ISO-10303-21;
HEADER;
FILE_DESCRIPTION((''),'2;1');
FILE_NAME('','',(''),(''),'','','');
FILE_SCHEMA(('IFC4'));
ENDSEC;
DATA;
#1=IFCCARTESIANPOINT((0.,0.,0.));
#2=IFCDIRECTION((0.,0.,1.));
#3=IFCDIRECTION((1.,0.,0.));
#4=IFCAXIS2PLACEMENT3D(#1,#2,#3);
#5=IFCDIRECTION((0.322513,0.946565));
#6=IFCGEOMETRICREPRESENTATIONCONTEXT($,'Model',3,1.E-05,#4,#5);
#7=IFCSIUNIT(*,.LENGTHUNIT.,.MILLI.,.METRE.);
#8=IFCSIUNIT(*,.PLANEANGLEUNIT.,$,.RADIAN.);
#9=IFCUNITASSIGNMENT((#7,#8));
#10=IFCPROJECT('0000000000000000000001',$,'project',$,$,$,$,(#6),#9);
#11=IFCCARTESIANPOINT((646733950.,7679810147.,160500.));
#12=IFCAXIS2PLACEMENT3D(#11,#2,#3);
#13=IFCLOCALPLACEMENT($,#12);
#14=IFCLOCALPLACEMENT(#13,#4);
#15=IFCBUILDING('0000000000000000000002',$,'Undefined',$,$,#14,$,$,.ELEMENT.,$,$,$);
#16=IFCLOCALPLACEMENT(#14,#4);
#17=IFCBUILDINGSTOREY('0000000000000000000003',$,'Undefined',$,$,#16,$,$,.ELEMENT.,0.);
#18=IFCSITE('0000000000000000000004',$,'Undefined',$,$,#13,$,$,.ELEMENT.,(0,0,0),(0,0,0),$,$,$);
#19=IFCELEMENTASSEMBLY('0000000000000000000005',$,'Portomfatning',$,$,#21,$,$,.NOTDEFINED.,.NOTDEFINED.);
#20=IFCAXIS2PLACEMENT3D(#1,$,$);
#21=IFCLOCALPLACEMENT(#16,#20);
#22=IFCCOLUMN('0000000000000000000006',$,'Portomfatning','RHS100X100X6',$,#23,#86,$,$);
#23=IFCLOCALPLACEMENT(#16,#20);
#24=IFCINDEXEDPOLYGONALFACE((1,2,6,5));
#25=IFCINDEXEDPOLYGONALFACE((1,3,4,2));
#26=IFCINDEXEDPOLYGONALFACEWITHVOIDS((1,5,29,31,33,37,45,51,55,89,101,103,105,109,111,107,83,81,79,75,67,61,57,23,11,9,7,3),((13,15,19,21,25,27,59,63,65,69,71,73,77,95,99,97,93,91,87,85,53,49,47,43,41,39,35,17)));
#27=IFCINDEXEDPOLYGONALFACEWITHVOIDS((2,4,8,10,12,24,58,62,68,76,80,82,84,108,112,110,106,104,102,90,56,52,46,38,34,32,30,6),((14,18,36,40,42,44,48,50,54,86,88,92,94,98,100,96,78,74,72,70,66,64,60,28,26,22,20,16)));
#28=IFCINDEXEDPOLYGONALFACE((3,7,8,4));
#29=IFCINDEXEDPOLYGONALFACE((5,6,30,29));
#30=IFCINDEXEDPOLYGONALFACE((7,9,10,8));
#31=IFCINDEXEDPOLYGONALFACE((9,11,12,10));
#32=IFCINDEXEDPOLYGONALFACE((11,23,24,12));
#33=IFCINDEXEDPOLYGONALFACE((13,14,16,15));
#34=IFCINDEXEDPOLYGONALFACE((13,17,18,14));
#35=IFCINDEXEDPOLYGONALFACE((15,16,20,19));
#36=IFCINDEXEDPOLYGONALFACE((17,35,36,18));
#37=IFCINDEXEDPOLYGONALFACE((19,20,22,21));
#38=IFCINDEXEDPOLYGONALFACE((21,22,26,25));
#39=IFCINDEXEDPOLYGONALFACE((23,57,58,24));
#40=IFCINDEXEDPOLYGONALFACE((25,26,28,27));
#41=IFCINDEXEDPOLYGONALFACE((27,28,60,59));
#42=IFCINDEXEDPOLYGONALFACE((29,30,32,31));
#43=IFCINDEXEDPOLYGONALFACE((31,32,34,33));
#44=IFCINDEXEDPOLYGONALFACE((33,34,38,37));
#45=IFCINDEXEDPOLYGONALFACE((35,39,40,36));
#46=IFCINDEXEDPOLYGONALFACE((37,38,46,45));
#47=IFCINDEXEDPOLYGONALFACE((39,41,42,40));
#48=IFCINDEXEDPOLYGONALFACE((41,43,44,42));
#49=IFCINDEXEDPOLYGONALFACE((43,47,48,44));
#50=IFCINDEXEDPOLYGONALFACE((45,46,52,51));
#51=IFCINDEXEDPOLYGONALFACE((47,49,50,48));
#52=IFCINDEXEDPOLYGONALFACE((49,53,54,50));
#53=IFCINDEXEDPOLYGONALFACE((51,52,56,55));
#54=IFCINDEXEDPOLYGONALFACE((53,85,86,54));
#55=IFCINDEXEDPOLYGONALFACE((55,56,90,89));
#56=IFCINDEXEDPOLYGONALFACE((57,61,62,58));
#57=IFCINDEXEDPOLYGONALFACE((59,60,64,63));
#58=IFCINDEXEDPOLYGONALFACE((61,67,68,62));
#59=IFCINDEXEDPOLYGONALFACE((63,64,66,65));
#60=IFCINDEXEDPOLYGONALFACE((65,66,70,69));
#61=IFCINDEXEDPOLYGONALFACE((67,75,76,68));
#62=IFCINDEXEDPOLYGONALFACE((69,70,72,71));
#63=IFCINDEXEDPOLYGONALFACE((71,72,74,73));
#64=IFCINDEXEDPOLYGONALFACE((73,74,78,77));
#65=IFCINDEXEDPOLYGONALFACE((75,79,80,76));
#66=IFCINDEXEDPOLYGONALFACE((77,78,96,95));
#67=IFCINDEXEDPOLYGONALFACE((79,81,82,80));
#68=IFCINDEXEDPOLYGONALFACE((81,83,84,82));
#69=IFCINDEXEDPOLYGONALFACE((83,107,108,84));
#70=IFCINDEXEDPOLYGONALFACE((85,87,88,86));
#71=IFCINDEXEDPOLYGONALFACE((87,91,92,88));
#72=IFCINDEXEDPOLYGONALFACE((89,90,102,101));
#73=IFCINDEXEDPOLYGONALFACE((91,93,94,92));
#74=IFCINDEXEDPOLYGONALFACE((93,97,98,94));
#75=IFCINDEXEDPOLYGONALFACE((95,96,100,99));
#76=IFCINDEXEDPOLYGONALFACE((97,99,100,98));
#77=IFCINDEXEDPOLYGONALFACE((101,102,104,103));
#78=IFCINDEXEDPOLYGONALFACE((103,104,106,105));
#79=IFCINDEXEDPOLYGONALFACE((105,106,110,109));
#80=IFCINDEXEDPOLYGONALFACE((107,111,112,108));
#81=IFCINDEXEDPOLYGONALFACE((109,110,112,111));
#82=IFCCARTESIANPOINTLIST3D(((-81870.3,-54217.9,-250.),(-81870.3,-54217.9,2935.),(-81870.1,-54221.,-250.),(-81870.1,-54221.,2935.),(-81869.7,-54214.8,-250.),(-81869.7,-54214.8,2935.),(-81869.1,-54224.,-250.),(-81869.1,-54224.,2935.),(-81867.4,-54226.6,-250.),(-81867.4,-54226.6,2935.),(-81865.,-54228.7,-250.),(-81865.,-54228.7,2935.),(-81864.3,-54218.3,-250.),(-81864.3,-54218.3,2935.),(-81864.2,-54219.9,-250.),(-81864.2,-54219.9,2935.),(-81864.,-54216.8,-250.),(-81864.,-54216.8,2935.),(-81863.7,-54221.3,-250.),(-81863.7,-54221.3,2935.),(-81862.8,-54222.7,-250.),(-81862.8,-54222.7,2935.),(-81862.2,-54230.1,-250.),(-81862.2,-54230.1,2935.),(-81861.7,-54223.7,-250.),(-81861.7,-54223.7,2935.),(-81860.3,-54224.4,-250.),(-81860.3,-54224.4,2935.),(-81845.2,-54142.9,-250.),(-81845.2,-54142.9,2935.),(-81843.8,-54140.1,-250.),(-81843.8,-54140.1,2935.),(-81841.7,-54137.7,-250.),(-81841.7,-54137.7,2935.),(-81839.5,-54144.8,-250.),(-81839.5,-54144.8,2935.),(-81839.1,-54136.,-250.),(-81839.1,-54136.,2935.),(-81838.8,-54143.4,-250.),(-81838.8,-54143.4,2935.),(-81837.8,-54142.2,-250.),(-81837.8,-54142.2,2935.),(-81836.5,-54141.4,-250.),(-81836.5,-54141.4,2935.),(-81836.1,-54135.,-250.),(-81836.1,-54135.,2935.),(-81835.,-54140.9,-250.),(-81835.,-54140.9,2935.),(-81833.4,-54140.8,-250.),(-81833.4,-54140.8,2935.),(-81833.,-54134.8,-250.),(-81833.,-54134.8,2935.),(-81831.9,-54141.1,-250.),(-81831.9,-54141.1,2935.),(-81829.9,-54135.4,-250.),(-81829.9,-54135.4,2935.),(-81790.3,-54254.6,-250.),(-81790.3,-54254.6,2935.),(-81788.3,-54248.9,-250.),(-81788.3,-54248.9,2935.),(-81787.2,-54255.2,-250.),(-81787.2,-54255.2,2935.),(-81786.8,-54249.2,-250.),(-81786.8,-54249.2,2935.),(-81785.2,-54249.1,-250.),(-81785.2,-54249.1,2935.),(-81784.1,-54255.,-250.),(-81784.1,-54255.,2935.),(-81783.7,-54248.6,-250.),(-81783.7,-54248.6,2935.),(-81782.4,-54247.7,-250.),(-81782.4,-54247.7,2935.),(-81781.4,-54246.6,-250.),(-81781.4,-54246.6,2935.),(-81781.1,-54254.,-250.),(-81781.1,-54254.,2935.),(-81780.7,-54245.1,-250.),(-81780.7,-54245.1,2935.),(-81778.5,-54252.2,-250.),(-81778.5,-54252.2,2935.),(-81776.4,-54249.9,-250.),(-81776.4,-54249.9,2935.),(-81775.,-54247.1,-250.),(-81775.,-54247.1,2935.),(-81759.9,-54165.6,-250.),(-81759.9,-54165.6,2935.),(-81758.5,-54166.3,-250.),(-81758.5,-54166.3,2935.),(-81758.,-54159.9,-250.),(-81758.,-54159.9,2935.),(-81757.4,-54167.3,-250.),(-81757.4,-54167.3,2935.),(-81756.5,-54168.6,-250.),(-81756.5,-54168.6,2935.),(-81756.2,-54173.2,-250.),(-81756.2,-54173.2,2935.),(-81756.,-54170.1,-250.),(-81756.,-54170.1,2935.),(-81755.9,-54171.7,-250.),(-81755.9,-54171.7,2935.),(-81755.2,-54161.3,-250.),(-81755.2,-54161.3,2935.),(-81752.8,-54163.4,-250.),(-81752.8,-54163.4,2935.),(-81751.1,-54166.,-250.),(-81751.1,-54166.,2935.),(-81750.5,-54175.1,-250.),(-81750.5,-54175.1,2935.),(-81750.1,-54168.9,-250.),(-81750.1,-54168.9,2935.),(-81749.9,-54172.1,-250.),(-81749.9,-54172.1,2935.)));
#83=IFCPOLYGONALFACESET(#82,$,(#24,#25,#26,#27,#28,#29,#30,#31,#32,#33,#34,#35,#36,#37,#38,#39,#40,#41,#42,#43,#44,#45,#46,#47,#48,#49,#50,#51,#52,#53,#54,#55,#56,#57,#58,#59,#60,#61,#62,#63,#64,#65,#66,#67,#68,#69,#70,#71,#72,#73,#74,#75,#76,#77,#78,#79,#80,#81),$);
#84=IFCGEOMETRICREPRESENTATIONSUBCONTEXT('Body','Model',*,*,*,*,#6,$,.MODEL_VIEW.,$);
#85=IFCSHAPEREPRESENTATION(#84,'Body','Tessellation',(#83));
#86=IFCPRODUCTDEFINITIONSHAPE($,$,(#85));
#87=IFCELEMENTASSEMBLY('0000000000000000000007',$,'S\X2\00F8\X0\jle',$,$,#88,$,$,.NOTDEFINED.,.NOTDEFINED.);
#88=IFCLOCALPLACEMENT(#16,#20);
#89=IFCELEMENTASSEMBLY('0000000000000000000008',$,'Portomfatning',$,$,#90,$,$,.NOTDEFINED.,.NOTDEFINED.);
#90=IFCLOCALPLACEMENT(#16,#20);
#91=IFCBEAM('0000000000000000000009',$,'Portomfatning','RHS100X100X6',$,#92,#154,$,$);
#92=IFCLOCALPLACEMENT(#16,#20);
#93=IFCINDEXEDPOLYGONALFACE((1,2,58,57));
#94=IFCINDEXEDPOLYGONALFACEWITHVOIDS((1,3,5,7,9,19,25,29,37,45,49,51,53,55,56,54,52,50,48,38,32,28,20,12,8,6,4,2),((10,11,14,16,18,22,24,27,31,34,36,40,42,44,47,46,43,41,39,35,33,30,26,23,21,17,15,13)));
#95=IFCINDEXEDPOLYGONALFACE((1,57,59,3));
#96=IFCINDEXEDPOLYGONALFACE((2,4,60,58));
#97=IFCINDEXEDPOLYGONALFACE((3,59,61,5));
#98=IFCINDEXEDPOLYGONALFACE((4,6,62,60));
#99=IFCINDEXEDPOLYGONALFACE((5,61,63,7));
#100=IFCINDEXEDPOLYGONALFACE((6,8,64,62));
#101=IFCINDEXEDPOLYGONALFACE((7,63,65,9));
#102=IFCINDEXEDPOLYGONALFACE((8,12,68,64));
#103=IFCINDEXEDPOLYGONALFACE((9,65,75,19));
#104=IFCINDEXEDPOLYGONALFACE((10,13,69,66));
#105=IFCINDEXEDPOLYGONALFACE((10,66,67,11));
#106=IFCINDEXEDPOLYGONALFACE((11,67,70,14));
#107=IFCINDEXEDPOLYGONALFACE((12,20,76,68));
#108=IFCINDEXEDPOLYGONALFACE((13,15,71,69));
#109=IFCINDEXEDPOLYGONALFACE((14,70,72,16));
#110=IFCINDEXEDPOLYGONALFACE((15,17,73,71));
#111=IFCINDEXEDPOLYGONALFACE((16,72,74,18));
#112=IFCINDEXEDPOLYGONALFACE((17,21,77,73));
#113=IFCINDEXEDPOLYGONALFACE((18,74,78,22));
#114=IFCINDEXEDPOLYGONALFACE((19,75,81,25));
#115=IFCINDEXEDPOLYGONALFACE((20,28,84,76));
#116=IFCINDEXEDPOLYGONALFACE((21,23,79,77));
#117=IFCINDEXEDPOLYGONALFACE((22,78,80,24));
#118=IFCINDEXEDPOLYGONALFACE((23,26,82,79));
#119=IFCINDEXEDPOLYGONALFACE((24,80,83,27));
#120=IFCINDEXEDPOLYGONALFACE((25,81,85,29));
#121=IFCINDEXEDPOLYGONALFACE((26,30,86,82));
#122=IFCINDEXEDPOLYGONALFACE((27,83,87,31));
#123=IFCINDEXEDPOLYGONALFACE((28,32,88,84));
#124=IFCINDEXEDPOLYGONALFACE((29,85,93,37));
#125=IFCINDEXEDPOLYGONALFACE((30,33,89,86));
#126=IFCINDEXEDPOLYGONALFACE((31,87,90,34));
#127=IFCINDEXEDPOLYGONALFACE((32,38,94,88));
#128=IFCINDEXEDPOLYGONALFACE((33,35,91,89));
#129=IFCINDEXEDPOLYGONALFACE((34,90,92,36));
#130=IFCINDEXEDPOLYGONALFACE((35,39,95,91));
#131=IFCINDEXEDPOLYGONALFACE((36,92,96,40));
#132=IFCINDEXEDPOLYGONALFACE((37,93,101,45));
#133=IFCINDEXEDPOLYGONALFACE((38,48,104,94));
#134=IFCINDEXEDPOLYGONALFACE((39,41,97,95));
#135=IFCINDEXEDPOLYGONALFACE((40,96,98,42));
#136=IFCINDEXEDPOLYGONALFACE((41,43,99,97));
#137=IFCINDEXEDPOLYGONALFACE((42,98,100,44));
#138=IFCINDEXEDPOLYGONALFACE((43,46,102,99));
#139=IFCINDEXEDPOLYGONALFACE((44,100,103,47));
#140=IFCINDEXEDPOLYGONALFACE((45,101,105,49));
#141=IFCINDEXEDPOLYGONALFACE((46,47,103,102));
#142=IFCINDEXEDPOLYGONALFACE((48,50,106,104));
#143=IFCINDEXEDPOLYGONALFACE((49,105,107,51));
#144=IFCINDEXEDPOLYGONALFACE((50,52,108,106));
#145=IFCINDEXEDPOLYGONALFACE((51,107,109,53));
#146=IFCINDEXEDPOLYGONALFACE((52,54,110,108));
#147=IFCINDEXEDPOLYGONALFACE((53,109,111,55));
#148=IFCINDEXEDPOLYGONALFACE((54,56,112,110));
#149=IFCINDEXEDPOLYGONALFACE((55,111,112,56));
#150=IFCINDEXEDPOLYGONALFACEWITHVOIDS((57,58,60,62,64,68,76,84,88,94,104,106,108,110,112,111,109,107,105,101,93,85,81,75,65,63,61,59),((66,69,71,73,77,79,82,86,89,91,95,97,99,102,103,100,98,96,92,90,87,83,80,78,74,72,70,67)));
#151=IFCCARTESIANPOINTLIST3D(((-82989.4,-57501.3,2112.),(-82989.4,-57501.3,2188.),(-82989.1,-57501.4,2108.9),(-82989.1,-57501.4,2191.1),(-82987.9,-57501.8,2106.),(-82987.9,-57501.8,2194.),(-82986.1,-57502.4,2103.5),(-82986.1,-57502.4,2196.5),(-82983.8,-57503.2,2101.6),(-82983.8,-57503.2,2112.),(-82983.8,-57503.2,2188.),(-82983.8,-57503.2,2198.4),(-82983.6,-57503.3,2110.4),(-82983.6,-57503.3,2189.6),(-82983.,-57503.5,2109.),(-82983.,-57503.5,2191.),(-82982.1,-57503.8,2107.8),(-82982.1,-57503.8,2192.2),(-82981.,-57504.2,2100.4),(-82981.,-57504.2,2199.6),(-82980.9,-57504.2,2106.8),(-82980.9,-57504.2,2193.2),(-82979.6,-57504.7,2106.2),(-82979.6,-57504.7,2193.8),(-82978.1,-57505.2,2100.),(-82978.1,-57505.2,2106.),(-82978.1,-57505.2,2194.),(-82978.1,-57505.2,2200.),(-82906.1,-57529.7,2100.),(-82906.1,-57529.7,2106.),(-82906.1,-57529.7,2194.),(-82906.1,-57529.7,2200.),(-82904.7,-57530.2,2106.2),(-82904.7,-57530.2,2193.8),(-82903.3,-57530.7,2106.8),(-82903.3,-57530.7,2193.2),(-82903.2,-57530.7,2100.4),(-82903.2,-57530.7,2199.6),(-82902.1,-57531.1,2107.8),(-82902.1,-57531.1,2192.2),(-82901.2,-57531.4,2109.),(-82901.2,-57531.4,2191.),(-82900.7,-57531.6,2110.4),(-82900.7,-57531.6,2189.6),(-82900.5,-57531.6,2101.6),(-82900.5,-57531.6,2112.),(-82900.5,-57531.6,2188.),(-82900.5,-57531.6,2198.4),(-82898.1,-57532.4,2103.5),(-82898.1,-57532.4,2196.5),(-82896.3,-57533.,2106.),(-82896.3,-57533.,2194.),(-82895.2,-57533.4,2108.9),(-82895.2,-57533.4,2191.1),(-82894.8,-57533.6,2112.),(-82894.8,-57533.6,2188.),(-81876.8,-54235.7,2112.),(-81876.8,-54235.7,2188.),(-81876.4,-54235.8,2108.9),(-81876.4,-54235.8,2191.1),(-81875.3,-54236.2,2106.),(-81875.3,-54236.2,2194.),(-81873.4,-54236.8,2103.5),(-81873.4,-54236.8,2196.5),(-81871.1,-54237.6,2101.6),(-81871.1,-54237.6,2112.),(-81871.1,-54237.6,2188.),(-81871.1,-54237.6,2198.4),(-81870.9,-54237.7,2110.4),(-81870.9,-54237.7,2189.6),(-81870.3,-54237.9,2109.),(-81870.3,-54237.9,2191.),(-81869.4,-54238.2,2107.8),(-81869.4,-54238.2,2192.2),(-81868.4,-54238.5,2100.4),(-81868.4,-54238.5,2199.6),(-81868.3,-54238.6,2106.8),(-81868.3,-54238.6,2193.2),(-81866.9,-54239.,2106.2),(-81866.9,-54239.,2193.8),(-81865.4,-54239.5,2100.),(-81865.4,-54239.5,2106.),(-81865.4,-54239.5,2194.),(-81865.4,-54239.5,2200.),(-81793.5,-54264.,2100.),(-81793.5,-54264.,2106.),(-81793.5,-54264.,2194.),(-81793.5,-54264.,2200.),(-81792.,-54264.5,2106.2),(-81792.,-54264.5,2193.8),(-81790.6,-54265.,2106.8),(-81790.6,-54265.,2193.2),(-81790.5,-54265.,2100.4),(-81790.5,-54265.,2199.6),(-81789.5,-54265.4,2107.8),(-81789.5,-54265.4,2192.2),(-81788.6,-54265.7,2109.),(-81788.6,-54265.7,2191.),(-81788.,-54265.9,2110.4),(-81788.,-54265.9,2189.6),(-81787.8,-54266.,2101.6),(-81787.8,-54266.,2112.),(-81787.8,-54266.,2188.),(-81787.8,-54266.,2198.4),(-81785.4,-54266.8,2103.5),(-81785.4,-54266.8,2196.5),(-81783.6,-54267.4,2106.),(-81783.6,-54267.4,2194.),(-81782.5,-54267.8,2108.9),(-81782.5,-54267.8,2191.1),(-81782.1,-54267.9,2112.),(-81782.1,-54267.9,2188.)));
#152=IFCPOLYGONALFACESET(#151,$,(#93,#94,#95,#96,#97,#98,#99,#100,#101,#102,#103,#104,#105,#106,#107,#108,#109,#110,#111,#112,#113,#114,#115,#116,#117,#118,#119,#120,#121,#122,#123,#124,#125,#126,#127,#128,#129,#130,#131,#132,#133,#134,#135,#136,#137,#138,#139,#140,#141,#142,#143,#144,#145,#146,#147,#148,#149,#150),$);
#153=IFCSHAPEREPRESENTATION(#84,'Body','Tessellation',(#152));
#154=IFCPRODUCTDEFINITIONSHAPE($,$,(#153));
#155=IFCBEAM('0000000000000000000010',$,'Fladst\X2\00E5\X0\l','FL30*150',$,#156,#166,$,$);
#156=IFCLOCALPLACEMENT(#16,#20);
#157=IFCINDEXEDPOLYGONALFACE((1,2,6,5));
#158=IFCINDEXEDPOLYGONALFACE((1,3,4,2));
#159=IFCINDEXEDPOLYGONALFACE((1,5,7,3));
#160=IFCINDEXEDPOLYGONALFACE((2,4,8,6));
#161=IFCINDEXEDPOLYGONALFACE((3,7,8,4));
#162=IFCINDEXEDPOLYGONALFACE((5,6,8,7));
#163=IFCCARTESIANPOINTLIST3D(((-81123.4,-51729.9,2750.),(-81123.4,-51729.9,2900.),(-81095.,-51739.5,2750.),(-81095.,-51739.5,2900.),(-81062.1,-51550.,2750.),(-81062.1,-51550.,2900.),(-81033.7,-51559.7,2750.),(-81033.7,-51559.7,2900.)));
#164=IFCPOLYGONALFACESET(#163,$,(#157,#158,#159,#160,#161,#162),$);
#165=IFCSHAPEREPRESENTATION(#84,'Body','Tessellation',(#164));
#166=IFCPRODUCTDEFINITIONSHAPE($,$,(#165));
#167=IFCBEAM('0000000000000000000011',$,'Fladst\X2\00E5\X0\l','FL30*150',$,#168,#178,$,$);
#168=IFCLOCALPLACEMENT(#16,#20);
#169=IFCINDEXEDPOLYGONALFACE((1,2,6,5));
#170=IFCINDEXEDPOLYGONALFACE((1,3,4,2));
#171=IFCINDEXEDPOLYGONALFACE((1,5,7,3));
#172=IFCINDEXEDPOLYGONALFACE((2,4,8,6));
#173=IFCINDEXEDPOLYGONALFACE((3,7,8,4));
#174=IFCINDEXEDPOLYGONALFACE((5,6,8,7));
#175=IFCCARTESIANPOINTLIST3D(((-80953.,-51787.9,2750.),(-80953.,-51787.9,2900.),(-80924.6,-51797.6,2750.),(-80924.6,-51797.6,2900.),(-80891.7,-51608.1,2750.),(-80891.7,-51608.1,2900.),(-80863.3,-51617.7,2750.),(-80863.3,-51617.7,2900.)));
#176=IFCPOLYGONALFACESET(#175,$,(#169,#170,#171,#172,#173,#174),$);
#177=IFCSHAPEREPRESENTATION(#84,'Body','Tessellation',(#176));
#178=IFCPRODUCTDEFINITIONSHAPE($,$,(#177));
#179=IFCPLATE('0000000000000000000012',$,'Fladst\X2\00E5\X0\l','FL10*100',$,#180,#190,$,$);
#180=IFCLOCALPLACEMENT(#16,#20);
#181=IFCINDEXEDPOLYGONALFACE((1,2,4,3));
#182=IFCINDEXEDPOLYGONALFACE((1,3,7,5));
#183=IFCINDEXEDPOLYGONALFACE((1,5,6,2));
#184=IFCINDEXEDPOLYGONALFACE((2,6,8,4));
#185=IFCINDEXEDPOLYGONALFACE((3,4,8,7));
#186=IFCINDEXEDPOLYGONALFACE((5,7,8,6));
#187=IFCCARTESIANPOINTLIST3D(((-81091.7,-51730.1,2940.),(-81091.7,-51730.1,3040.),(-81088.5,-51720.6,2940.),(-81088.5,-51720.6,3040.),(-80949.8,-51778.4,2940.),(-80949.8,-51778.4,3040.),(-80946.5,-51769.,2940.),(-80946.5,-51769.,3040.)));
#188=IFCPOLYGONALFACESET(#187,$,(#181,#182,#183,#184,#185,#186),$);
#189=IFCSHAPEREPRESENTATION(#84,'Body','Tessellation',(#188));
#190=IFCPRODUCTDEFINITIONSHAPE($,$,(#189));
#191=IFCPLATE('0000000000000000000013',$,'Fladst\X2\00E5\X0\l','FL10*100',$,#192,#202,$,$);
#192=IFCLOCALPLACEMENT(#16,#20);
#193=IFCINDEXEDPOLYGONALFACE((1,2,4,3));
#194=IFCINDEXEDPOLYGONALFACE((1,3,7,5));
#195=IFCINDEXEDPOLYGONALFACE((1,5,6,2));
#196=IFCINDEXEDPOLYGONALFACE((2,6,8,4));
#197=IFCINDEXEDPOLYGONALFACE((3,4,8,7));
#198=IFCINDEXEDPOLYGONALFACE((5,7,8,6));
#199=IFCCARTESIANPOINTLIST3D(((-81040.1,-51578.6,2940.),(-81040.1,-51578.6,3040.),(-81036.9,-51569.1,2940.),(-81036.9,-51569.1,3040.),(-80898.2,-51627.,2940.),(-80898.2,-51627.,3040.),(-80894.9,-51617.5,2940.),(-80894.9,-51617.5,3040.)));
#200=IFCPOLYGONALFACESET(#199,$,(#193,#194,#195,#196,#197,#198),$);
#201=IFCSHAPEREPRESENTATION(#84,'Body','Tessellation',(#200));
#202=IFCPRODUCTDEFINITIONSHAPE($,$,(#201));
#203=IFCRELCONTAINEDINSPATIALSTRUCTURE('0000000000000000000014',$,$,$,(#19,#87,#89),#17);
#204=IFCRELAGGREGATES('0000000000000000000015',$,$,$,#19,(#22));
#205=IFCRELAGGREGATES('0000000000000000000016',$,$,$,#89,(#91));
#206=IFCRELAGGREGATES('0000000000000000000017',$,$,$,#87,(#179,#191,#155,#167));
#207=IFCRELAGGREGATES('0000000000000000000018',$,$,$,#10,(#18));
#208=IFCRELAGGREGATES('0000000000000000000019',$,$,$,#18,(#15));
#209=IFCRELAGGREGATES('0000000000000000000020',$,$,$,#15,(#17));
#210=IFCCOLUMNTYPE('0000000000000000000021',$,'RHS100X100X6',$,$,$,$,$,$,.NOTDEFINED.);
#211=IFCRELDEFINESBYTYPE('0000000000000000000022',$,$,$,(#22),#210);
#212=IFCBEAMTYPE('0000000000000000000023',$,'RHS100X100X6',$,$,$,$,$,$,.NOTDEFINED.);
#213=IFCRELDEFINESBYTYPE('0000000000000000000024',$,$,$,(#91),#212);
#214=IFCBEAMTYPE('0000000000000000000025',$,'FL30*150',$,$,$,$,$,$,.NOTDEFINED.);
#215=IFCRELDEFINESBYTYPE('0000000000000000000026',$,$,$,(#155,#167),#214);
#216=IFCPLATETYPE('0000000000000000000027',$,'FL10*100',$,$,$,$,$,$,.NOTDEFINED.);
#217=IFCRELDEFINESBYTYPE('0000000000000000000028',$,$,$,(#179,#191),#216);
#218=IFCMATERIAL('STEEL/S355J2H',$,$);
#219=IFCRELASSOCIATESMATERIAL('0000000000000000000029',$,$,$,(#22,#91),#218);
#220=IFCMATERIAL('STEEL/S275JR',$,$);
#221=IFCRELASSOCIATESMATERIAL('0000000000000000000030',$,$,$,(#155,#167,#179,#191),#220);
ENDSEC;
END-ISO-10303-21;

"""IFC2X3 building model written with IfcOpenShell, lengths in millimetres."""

from ifc_helpers import new_model, si_unit, direction, frame, origin_with_axes, origin_2d_with_axis, place, context, subcontext, project, spatial, polyline, rectangle, hollow_rectangle, outline, extrude, clip, halfspace, material, type_object, element, aggregate, save


model = new_model("IFC2X3")

# Units and contexts
model_context = context("Model", 3, precision=1e-05, world=origin_with_axes(), true_north=direction((0.322513, 0.946565)))
body_context = subcontext(model_context, "Body", "Model", "MODEL_VIEW")
ifc_project = project(units=[si_unit("LENGTHUNIT", "METRE", prefix="MILLI"), si_unit("PLANEANGLEUNIT", "RADIAN")], contexts=[model_context])

# Site, building, storey
site_placement = place(None, frame((646733950.0, 7679810147.0, 160500.0), z_axis=(0.0, 0.0, 1.0), x_axis=(1.0, 0.0, 0.0)))
site = spatial("IfcSite", under=ifc_project, at=site_placement, Name="Undefined", CompositionType="ELEMENT", RefLatitude=(0, 0, 0), RefLongitude=(0, 0, 0))
building_placement = place(site_placement, origin_with_axes())
building = spatial("IfcBuilding", under=site, at=building_placement, Name="Undefined", CompositionType="ELEMENT")
storey_placement = place(building_placement, origin_with_axes())
storey = spatial("IfcBuildingStorey", under=building, at=storey_placement, Name="Undefined", CompositionType="ELEMENT", Elevation=0.0)

# Element assemblies, column
assembly_1_placement = place(storey_placement, origin_with_axes())
assembly_1 = element("IfcElementAssembly", 1, at=assembly_1_placement, inside=storey, Name="Portomfatning", AssemblyPlace="NOTDEFINED", PredefinedType="NOTDEFINED")
ifc_material_1 = material(Name="STEEL/S355J2H")
column_type_1 = type_object("IfcColumnType", Name="RHS100X100X6", PredefinedType="NOTDEFINED")
column_1_placement = place(assembly_1_placement, frame((-81810.1, -54195.0, -250.0), z_axis=(0.0, 0.0, 1.0), x_axis=(0.946565, -0.322513, 0.0)))
column_1 = element("IfcColumn", 2, at=column_1_placement, type_object=column_type_1, material=ifc_material_1, Name="Portomfatning", Description="RHS100X100X6", context=body_context, shape_type="SweptSolid", body=[
    extrude(hollow_rectangle(XDim=100.0, YDim=100.0, WallThickness=6.0, InnerFilletRadius=6.0, OuterFilletRadius=12.0, at=origin_2d_with_axis()), frame((0.0, 0.0, 3185.0), z_axis=(0.0, 0.0, -1.0), x_axis=(0.0, 1.0, 0.0)), (0.0, 0.0, 1.0), 3185.0),
])
aggregate(assembly_1, [column_1])
assembly_2_placement = place(storey_placement, origin_with_axes())
assembly_2 = element("IfcElementAssembly", 3, at=assembly_2_placement, inside=storey, Name="Søjle", AssemblyPlace="NOTDEFINED", PredefinedType="NOTDEFINED")

# Element assembly, beam
assembly_3_placement = place(storey_placement, origin_with_axes())
assembly_3 = element("IfcElementAssembly", 4, at=assembly_3_placement, inside=storey, Name="Portomfatning", AssemblyPlace="NOTDEFINED", PredefinedType="NOTDEFINED")
beam_type_1 = type_object("IfcBeamType", Name="RHS100X100X6", PredefinedType="NOTDEFINED")
beam_1_placement = place(assembly_3_placement, frame((-81826.2, -54242.3, 2150.0), z_axis=(0.946565, -0.322513, 0.0), x_axis=(-0.322513, -0.946565, 0.0)))
beam_1 = element("IfcBeam", 5, at=beam_1_placement, type_object=beam_type_1, material=ifc_material_1, Name="Portomfatning", Description="RHS100X100X6", context=body_context, shape_type="Clipping", body=[
    clip(clip(extrude(hollow_rectangle(XDim=100.0, YDim=100.0, WallThickness=6.0, InnerFilletRadius=6.0, OuterFilletRadius=12.0, at=origin_2d_with_axis()), frame((3521.7, 0.0, 0.0), z_axis=(-1.0, 0.0, 0.0), x_axis=(0.0, -1.0, 0.0)), (0.0, 0.0, 1.0), 3573.3), halfspace(frame((3460.0, 50.0, 0.0), z_axis=(-1.0, 0.0, 0.0), x_axis=(0.0, 0.0, 1.0)), True)), halfspace(frame((10.0, 50.0, 0.0), z_axis=(1.0, 0.0, 0.0), x_axis=(0.0, 0.0, -1.0)), True)),
])

# Beams
ifc_material_2 = material(Name="STEEL/S275JR")
beam_type_2 = type_object("IfcBeamType", Name="FL30*150", PredefinedType="NOTDEFINED")
beam_2_placement = place(assembly_2_placement, frame((-81078.5, -51644.8, 2900.0), z_axis=(-0.322513, -0.946565, 0.0), x_axis=(0.0, 0.0, -1.0)))
beam_2 = element("IfcBeam", 6, at=beam_2_placement, type_object=beam_type_2, material=ifc_material_2, Name="Fladstål", Description="FL30*150", context=body_context, shape_type="SweptSolid", body=[
    extrude(rectangle(XDim=30.0, YDim=190.0, at=origin_2d_with_axis()), frame((150.0, 0.0, 0.0), z_axis=(-1.0, 0.0, 0.0), x_axis=(0.0, -1.0, 0.0)), (0.0, 0.0, 1.0), 150.0),
])
beam_3_placement = place(assembly_2_placement, frame((-80908.1, -51702.8, 2900.0), z_axis=(-0.322513, -0.946565, 0.0), x_axis=(0.0, 0.0, -1.0)))
beam_3 = element("IfcBeam", 7, at=beam_3_placement, type_object=beam_type_2, material=ifc_material_2, Name="Fladstål", Description="FL30*150", context=body_context, shape_type="SweptSolid", body=[
    extrude(rectangle(XDim=30.0, YDim=190.0, at=origin_2d_with_axis()), frame((150.0, 0.0, 0.0), z_axis=(-1.0, 0.0, 0.0), x_axis=(0.0, -1.0, 0.0)), (0.0, 0.0, 1.0), 150.0),
])

# Plates
plate_type_1 = type_object("IfcPlateType", Name="FL10*100", PredefinedType="NOTDEFINED")
plate_1_placement = place(assembly_2_placement, frame((-80948.1, -51773.7, 3040.0), z_axis=(-0.322513, -0.946565, 0.0), x_axis=(-0.946565, 0.322513, 0.0)))
plate_1 = element("IfcPlate", 8, at=plate_1_placement, type_object=plate_type_1, material=ifc_material_2, Name="Fladstål", Description="FL10*100", context=body_context, shape_type="SweptSolid", body=[
    extrude(outline(polyline([(0.0, 0.0), (150.0, 0.0), (150.0, 100.0), (0.0, 100.0), (0.0, 0.0)])), frame((0.0, 0.0, -5.0), z_axis=(0.0, 0.0, 1.0), x_axis=(1.0, 0.0, 0.0)), (0.0, 0.0, 1.0), 10.0),
])
plate_2_placement = place(assembly_2_placement, frame((-80896.5, -51622.3, 3040.0), z_axis=(-0.322513, -0.946565, 0.0), x_axis=(-0.946565, 0.322513, 0.0)))
plate_2 = element("IfcPlate", 9, at=plate_2_placement, type_object=plate_type_1, material=ifc_material_2, Name="Fladstål", Description="FL10*100", context=body_context, shape_type="SweptSolid", body=[
    extrude(outline(polyline([(0.0, 0.0), (150.0, 0.0), (150.0, 100.0), (0.0, 100.0), (0.0, 0.0)])), frame((0.0, 0.0, -5.0), z_axis=(0.0, 0.0, 1.0), x_axis=(1.0, 0.0, 0.0)), (0.0, 0.0, 1.0), 10.0),
])

aggregate(assembly_3, [beam_1])
aggregate(assembly_2, [plate_1, plate_2, beam_2, beam_3])

save(model, "model.ifc")
